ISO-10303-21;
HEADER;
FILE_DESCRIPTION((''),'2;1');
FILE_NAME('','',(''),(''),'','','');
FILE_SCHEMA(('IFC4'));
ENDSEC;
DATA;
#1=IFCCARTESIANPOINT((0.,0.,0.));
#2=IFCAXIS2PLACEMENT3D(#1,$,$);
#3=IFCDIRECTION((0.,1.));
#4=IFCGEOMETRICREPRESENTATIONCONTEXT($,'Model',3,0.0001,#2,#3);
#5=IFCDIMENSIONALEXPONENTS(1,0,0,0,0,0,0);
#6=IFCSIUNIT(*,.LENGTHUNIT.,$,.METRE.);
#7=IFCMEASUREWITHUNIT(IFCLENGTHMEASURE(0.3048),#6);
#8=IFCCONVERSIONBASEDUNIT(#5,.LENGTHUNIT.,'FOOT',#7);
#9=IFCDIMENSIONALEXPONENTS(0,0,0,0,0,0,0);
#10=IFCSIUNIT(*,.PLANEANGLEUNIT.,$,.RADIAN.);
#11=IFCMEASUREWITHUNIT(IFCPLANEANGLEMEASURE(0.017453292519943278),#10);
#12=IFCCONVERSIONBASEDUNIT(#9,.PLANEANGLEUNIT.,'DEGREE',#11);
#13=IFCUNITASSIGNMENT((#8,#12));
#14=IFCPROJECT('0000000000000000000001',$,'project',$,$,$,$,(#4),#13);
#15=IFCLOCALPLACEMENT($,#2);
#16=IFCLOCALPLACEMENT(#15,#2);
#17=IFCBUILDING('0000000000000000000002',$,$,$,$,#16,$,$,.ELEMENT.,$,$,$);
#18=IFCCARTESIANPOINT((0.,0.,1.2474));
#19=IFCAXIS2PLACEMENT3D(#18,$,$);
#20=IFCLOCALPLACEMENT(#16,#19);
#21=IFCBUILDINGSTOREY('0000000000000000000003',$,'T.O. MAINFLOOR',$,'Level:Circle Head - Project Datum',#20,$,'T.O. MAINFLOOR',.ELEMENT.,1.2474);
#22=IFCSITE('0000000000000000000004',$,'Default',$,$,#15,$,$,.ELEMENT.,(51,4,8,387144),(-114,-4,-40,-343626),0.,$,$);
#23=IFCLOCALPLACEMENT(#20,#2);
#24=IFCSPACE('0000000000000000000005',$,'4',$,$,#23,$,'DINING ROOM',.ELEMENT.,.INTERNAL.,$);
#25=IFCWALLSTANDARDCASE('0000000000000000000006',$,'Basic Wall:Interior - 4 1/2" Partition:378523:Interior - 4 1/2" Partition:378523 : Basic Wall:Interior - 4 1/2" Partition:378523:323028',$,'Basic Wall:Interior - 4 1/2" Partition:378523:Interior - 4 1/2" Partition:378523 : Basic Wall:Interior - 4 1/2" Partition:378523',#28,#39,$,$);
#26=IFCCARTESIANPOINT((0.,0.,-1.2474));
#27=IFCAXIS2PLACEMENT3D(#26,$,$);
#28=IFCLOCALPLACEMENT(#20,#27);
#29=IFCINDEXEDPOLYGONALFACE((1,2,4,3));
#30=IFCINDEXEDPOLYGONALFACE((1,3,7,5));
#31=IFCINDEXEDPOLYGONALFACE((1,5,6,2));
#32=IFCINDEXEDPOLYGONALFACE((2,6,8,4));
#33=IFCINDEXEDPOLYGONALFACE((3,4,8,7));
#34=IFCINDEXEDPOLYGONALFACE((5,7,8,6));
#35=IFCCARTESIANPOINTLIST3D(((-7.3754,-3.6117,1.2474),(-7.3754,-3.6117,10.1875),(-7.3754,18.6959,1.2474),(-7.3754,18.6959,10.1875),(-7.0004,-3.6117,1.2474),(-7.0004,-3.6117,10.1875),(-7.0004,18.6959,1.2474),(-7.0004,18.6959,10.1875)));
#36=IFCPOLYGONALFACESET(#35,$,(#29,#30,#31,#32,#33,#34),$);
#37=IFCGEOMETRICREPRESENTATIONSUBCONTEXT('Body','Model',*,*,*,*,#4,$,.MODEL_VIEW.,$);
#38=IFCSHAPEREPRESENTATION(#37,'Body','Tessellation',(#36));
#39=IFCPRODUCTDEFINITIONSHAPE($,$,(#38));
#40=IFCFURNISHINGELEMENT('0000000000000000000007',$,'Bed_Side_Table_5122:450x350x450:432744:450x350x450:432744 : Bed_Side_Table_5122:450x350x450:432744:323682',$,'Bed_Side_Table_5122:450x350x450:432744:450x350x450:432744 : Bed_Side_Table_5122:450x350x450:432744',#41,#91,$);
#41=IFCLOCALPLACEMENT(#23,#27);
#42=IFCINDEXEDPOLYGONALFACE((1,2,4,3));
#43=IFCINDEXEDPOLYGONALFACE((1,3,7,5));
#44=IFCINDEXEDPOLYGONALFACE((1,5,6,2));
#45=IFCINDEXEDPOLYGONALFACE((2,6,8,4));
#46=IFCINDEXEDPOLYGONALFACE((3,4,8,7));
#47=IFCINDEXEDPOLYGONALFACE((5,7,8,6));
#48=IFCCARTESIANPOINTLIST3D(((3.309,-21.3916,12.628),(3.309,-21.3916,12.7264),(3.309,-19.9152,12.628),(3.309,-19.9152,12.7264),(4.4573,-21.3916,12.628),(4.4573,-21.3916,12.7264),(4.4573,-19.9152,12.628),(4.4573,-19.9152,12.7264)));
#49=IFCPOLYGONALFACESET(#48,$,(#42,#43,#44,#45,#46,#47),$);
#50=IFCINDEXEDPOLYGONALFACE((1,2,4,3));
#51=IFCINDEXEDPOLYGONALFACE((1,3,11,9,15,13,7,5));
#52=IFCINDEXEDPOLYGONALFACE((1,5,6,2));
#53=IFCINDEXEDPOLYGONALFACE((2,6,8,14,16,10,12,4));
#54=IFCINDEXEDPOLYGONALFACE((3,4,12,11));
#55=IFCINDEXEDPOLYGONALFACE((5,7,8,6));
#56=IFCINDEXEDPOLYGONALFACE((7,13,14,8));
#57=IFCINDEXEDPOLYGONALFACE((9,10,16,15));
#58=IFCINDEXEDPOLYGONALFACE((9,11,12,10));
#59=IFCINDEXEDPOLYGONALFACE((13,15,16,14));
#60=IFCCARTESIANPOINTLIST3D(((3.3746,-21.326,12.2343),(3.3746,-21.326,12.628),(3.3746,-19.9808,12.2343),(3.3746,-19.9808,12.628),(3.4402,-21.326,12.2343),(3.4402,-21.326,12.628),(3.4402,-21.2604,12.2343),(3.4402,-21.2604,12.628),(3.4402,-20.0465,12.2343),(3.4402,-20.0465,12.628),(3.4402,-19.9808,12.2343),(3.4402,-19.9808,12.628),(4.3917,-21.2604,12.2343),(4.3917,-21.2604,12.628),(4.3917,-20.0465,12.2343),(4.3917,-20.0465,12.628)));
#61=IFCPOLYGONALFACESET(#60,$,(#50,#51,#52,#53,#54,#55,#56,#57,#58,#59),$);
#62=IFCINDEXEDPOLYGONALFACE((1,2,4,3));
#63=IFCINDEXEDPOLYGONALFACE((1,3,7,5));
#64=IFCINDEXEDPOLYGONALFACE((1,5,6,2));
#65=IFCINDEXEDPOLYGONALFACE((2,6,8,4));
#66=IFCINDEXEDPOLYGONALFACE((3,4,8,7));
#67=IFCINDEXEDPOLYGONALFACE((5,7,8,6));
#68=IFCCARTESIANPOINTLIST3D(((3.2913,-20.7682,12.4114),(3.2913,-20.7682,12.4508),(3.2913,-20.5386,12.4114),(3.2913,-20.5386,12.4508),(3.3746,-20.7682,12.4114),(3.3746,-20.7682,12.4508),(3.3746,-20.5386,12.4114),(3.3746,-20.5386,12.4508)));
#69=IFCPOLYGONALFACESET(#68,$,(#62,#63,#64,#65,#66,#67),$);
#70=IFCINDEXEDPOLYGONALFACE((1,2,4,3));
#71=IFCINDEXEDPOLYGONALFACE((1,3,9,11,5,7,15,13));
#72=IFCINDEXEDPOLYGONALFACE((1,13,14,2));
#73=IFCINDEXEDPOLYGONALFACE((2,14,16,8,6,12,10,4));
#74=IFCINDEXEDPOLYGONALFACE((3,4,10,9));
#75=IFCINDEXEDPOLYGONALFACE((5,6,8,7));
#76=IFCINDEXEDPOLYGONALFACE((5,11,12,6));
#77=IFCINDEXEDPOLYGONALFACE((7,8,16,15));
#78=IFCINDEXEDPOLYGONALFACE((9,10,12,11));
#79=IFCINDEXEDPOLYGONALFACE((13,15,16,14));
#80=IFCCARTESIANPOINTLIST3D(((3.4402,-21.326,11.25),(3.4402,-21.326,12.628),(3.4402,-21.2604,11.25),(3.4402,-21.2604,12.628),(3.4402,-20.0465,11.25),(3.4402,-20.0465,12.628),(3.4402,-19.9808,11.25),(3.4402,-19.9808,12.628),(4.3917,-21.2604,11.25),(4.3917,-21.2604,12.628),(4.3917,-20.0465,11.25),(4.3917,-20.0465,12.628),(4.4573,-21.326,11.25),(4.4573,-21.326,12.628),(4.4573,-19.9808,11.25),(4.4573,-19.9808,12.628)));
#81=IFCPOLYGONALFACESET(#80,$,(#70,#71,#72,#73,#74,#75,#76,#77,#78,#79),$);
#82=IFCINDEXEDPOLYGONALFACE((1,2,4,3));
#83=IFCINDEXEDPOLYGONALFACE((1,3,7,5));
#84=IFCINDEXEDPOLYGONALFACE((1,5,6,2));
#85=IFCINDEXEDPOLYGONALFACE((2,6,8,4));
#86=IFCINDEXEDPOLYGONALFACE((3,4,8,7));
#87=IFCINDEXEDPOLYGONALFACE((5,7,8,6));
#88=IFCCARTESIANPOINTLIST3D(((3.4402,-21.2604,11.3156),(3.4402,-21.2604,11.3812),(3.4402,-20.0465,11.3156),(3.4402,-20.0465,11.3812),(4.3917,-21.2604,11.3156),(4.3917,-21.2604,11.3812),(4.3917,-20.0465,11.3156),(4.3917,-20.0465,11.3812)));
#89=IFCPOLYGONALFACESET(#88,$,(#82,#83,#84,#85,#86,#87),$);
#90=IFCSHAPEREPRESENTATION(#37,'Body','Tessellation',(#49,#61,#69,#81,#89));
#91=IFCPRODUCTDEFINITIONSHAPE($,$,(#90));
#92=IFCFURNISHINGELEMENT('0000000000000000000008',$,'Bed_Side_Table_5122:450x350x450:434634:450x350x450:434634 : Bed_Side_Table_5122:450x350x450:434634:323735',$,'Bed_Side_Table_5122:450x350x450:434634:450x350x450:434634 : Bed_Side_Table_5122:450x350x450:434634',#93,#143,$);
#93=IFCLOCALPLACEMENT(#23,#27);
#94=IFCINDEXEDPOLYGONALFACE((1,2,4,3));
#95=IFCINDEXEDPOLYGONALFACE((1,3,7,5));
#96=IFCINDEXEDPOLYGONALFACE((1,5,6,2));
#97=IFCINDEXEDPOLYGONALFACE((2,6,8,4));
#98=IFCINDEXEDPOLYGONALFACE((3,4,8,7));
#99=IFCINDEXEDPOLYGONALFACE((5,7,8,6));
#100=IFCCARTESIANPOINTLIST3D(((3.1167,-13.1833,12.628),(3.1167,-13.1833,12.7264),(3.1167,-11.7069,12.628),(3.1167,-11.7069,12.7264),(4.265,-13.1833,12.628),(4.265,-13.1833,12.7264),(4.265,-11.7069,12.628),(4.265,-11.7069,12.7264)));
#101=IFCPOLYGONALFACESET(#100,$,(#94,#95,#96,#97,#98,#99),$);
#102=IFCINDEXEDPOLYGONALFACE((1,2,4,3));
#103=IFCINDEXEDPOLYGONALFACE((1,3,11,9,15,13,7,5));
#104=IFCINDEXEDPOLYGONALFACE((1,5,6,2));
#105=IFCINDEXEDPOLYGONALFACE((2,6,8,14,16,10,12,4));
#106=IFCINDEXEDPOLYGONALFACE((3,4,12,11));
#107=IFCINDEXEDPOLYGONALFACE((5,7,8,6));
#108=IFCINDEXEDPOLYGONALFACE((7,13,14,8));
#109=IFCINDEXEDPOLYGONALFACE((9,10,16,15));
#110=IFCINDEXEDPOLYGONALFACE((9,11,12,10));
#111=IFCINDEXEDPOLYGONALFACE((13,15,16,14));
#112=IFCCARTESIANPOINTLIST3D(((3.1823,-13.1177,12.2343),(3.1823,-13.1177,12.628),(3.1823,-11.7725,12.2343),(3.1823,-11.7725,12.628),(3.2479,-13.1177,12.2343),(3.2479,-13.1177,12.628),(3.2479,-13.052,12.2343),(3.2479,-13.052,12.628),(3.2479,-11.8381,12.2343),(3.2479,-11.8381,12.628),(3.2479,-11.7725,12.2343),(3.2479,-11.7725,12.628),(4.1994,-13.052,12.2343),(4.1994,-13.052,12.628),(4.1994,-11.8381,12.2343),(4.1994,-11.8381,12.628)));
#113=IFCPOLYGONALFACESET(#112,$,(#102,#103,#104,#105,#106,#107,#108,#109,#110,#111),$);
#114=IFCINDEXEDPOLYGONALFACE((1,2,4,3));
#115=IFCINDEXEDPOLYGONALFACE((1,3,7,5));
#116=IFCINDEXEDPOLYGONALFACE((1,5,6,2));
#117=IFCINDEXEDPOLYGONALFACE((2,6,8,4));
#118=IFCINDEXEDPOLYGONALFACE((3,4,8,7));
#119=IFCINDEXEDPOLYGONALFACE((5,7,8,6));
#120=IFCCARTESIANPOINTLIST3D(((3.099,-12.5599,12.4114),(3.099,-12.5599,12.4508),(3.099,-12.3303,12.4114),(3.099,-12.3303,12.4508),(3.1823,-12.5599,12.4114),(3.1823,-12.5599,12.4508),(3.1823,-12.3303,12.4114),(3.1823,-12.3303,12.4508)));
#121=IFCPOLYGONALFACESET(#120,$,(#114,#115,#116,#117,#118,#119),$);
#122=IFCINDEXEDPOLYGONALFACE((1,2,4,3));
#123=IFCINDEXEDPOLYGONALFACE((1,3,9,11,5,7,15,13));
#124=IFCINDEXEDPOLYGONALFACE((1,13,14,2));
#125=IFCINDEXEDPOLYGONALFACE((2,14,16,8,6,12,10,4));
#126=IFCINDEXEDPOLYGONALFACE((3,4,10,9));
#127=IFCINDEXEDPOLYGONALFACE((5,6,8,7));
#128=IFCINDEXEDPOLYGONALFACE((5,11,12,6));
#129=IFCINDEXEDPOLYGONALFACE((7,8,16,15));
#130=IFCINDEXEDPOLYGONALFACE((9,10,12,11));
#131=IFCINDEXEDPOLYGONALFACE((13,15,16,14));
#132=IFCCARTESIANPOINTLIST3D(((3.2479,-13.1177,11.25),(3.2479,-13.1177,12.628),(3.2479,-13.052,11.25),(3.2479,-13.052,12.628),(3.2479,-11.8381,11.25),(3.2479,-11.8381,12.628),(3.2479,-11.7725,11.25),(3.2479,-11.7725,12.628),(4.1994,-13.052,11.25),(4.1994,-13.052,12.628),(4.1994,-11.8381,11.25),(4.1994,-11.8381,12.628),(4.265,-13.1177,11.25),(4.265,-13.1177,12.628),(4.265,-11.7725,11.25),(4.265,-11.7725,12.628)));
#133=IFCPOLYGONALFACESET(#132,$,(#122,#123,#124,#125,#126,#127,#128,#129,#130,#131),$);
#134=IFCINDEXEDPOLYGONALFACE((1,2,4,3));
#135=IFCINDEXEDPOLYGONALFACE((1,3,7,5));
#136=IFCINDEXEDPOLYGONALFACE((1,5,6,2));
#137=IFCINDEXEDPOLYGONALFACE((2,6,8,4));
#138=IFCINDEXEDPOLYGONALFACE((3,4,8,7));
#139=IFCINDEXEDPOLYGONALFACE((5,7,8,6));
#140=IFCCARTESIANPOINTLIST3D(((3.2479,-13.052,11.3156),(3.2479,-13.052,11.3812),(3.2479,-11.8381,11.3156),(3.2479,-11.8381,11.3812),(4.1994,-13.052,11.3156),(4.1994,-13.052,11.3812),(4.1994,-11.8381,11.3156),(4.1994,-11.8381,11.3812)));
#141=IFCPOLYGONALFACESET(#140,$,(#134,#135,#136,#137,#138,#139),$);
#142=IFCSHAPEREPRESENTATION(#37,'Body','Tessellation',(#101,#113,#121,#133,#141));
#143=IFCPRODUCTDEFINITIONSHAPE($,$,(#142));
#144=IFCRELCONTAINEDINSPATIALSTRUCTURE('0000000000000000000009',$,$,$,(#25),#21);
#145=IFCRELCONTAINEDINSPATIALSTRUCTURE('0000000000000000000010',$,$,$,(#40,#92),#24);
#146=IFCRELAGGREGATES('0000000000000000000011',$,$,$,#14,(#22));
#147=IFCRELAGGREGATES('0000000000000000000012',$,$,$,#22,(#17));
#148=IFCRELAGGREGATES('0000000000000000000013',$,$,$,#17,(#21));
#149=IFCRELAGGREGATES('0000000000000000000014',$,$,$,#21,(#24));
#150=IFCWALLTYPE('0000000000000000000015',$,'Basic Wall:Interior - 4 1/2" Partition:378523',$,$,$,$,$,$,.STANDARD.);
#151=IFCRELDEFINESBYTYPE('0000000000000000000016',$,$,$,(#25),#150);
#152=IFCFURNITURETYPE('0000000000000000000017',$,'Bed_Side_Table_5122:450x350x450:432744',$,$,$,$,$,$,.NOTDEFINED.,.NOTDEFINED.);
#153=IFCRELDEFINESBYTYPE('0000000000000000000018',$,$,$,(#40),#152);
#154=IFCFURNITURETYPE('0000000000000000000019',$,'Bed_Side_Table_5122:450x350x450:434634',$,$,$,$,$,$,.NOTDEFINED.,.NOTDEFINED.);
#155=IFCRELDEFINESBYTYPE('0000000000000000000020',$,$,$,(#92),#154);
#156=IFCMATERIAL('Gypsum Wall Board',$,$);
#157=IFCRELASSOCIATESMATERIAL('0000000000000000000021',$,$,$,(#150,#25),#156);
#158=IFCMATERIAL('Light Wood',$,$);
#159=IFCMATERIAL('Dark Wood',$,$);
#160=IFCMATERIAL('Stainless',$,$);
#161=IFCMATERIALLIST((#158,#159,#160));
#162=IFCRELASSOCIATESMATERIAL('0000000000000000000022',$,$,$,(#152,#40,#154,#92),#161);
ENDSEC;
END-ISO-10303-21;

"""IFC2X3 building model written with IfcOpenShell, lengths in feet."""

from ifc_helpers import new_model, entity, si_unit, converted_unit, direction, frame, frame_2d, origin, origin_2d_with_axis, place, context, subcontext, project, spatial, polyline, rectangle, outline, extrude, source, transform, mapped, material, material_list, type_object, type_shapes, element, save


model = new_model("IFC2X3")

# Units and contexts
model_context = context("Model", 3, precision=0.0001, world=origin(), true_north=direction((0.0, 1.0)))
body_context = subcontext(model_context, "Body", "Model", "MODEL_VIEW")
ifc_project = project(units=[converted_unit("LENGTHUNIT", "FOOT", entity("IfcLengthMeasure", 0.3048), si_unit("LENGTHUNIT", "METRE"), dimensions=[1, 0, 0, 0, 0, 0, 0]), converted_unit("PLANEANGLEUNIT", "DEGREE", entity("IfcPlaneAngleMeasure", 0.017453292519943278), si_unit("PLANEANGLEUNIT", "RADIAN"), dimensions=[0, 0, 0, 0, 0, 0, 0])], contexts=[model_context])

# Site, building, storey
site_placement = place(None, origin())
site = spatial("IfcSite", under=ifc_project, at=site_placement, Name="Default", CompositionType="ELEMENT", RefLatitude=(51, 4, 8, 387144), RefLongitude=(-114, -4, -40, -343626), RefElevation=0.0)
building_placement = place(site_placement, origin())
building = spatial("IfcBuilding", under=site, at=building_placement, CompositionType="ELEMENT")
storey_placement = place(building_placement, frame((0.0, 0.0, 1.2474)))
storey = spatial("IfcBuildingStorey", under=building, at=storey_placement, Name="T.O. MAINFLOOR", ObjectType="Level:Circle Head - Project Datum", LongName="T.O. MAINFLOOR", CompositionType="ELEMENT", Elevation=1.2474)

# Wall
ifc_material_1 = material(Name="Gypsum Wall Board")
wall_type_1 = type_object("IfcWallType", Name="Basic Wall:Interior - 4 1/2\" Partition:378523", PredefinedType="STANDARD", material=ifc_material_1)
shared_shape_1 = source(origin(), body_context, "Body", "SweptSolid", [
    extrude(rectangle(XDim=22.3077, YDim=0.375, at=origin_2d_with_axis()), frame((-7.1879, 7.5421, 1.2474), z_axis=(0.0, 0.0, 1.0), x_axis=(0.0, 1.0, 0.0)), (0.0, 0.0, 1.0), 8.9401),
])
type_shapes(wall_type_1, [shared_shape_1])
wall_1_placement = place(storey_placement, frame((0.0, 0.0, -1.2474)))
element("IfcWallStandardCase", 1, at=wall_1_placement, inside=storey, type_object=wall_type_1, material=ifc_material_1, Name="Basic Wall:Interior - 4 1/2\" Partition:378523:Interior - 4 1/2\" Partition:378523 : Basic Wall:Interior - 4 1/2\" Partition:378523:323028", ObjectType="Basic Wall:Interior - 4 1/2\" Partition:378523:Interior - 4 1/2\" Partition:378523 : Basic Wall:Interior - 4 1/2\" Partition:378523", context=body_context, shape_type="MappedRepresentation", body=[
    mapped(shared_shape_1, transform((0.0, 0.0, 0.0), scale=1.0)),
])

# Shared definitions
space_placement = place(storey_placement, origin())
space = spatial("IfcSpace", under=storey, at=space_placement, Name="4", LongName="DINING ROOM", CompositionType="ELEMENT", InteriorOrExteriorSpace="INTERNAL")

# Furnishing elements
ifc_material_2 = material(Name="Light Wood")
ifc_material_3 = material(Name="Dark Wood")
ifc_material_4 = material(Name="Stainless")
ifc_material_list_1 = material_list([ifc_material_2, ifc_material_3, ifc_material_4])
furniture_type_1 = type_object("IfcFurnitureType", Name="Bed_Side_Table_5122:450x350x450:432744", AssemblyPlace="NOTDEFINED", material=ifc_material_list_1)
shared_shape_2 = source(origin(), body_context, "Body", "SweptSolid", [
    extrude(rectangle(XDim=1.1483, YDim=1.4764, at=frame_2d((0.0, 0.0), x_axis=(1.0, 0.0))), frame((3.8832, -20.6534, 12.628), z_axis=(0.0, 0.0, 1.0), x_axis=(-1.0, 0.0, 0.0)), (0.0, 0.0, 1.0), 0.0984),
    extrude(outline(polyline([(-0.2215, -0.607), (0.73, -0.607), (0.73, 0.607), (-0.2215, 0.607), (-0.2215, 0.6726), (-0.2871, 0.6726), (-0.2871, -0.6726), (-0.2215, -0.6726), (-0.2215, -0.607)])), frame((3.6617, -20.6534, 12.2343)), (0.0, 0.0, 1.0), 0.3937),
    extrude(rectangle(XDim=0.0833, YDim=0.2297, at=origin_2d_with_axis()), frame((3.333, -20.6534, 12.4114)), (0.0, 0.0, 1.0), 0.0394),
    extrude(outline(polyline([(-0.6726, -0.5249), (0.6726, -0.5249), (0.6726, 0.4921), (0.607, 0.4921), (0.607, -0.4593), (-0.607, -0.4593), (-0.607, 0.4921), (-0.6726, 0.4921), (-0.6726, -0.5249)])), frame((3.9324, -20.6534, 11.25), z_axis=(0.0, 0.0, 1.0), x_axis=(0.0, 1.0, 0.0)), (0.0, 0.0, 1.0), 1.378),
    extrude(rectangle(XDim=0.9514, YDim=1.2139, at=frame_2d((0.0, 0.0), x_axis=(1.0, 0.0))), frame((3.916, -20.6534, 11.3156)), (0.0, 0.0, 1.0), 0.0656),
])
type_shapes(furniture_type_1, [shared_shape_2])
furnishing_1_placement = place(space_placement, frame((0.0, 0.0, -1.2474)))
element("IfcFurnishingElement", 2, at=furnishing_1_placement, inside=space, type_object=furniture_type_1, material=ifc_material_list_1, Name="Bed_Side_Table_5122:450x350x450:432744:450x350x450:432744 : Bed_Side_Table_5122:450x350x450:432744:323682", ObjectType="Bed_Side_Table_5122:450x350x450:432744:450x350x450:432744 : Bed_Side_Table_5122:450x350x450:432744", context=body_context, shape_type="MappedRepresentation", body=[
    mapped(shared_shape_2, transform((0.0, 0.0, 0.0), scale=1.0)),
])
furniture_type_2 = type_object("IfcFurnitureType", Name="Bed_Side_Table_5122:450x350x450:434634", AssemblyPlace="NOTDEFINED", material=ifc_material_list_1)
shared_shape_3 = source(origin(), body_context, "Body", "SweptSolid", [
    extrude(rectangle(XDim=1.1483, YDim=1.4764, at=frame_2d((0.0, 0.0), x_axis=(1.0, 0.0))), frame((3.6908, -12.4451, 12.628), z_axis=(0.0, 0.0, 1.0), x_axis=(-1.0, 0.0, 0.0)), (0.0, 0.0, 1.0), 0.0984),
    extrude(outline(polyline([(-0.2215, -0.607), (0.73, -0.607), (0.73, 0.607), (-0.2215, 0.607), (-0.2215, 0.6726), (-0.2871, 0.6726), (-0.2871, -0.6726), (-0.2215, -0.6726), (-0.2215, -0.607)])), frame((3.4694, -12.4451, 12.2343)), (0.0, 0.0, 1.0), 0.3937),
    extrude(rectangle(XDim=0.0833, YDim=0.2297, at=frame_2d((0.0, 0.0), x_axis=(1.0, 0.0))), frame((3.1406, -12.4451, 12.4114)), (0.0, 0.0, 1.0), 0.0394),
    extrude(outline(polyline([(-0.6726, -0.5249), (0.6726, -0.5249), (0.6726, 0.4921), (0.607, 0.4921), (0.607, -0.4593), (-0.607, -0.4593), (-0.607, 0.4921), (-0.6726, 0.4921), (-0.6726, -0.5249)])), frame((3.74, -12.4451, 11.25), z_axis=(0.0, 0.0, 1.0), x_axis=(0.0, 1.0, 0.0)), (0.0, 0.0, 1.0), 1.378),
    extrude(rectangle(XDim=0.9514, YDim=1.2139, at=frame_2d((0.0, 0.0), x_axis=(1.0, 0.0))), frame((3.7236, -12.4451, 11.3156)), (0.0, 0.0, 1.0), 0.0656),
])
type_shapes(furniture_type_2, [shared_shape_3])
furnishing_2_placement = place(space_placement, frame((0.0, 0.0, -1.2474)))
element("IfcFurnishingElement", 3, at=furnishing_2_placement, inside=space, type_object=furniture_type_2, material=ifc_material_list_1, Name="Bed_Side_Table_5122:450x350x450:434634:450x350x450:434634 : Bed_Side_Table_5122:450x350x450:434634:323735", ObjectType="Bed_Side_Table_5122:450x350x450:434634:450x350x450:434634 : Bed_Side_Table_5122:450x350x450:434634", context=body_context, shape_type="MappedRepresentation", body=[
    mapped(shared_shape_3, transform((0.0, 0.0, 0.0), scale=1.0)),
])

save(model, "model.ifc")
